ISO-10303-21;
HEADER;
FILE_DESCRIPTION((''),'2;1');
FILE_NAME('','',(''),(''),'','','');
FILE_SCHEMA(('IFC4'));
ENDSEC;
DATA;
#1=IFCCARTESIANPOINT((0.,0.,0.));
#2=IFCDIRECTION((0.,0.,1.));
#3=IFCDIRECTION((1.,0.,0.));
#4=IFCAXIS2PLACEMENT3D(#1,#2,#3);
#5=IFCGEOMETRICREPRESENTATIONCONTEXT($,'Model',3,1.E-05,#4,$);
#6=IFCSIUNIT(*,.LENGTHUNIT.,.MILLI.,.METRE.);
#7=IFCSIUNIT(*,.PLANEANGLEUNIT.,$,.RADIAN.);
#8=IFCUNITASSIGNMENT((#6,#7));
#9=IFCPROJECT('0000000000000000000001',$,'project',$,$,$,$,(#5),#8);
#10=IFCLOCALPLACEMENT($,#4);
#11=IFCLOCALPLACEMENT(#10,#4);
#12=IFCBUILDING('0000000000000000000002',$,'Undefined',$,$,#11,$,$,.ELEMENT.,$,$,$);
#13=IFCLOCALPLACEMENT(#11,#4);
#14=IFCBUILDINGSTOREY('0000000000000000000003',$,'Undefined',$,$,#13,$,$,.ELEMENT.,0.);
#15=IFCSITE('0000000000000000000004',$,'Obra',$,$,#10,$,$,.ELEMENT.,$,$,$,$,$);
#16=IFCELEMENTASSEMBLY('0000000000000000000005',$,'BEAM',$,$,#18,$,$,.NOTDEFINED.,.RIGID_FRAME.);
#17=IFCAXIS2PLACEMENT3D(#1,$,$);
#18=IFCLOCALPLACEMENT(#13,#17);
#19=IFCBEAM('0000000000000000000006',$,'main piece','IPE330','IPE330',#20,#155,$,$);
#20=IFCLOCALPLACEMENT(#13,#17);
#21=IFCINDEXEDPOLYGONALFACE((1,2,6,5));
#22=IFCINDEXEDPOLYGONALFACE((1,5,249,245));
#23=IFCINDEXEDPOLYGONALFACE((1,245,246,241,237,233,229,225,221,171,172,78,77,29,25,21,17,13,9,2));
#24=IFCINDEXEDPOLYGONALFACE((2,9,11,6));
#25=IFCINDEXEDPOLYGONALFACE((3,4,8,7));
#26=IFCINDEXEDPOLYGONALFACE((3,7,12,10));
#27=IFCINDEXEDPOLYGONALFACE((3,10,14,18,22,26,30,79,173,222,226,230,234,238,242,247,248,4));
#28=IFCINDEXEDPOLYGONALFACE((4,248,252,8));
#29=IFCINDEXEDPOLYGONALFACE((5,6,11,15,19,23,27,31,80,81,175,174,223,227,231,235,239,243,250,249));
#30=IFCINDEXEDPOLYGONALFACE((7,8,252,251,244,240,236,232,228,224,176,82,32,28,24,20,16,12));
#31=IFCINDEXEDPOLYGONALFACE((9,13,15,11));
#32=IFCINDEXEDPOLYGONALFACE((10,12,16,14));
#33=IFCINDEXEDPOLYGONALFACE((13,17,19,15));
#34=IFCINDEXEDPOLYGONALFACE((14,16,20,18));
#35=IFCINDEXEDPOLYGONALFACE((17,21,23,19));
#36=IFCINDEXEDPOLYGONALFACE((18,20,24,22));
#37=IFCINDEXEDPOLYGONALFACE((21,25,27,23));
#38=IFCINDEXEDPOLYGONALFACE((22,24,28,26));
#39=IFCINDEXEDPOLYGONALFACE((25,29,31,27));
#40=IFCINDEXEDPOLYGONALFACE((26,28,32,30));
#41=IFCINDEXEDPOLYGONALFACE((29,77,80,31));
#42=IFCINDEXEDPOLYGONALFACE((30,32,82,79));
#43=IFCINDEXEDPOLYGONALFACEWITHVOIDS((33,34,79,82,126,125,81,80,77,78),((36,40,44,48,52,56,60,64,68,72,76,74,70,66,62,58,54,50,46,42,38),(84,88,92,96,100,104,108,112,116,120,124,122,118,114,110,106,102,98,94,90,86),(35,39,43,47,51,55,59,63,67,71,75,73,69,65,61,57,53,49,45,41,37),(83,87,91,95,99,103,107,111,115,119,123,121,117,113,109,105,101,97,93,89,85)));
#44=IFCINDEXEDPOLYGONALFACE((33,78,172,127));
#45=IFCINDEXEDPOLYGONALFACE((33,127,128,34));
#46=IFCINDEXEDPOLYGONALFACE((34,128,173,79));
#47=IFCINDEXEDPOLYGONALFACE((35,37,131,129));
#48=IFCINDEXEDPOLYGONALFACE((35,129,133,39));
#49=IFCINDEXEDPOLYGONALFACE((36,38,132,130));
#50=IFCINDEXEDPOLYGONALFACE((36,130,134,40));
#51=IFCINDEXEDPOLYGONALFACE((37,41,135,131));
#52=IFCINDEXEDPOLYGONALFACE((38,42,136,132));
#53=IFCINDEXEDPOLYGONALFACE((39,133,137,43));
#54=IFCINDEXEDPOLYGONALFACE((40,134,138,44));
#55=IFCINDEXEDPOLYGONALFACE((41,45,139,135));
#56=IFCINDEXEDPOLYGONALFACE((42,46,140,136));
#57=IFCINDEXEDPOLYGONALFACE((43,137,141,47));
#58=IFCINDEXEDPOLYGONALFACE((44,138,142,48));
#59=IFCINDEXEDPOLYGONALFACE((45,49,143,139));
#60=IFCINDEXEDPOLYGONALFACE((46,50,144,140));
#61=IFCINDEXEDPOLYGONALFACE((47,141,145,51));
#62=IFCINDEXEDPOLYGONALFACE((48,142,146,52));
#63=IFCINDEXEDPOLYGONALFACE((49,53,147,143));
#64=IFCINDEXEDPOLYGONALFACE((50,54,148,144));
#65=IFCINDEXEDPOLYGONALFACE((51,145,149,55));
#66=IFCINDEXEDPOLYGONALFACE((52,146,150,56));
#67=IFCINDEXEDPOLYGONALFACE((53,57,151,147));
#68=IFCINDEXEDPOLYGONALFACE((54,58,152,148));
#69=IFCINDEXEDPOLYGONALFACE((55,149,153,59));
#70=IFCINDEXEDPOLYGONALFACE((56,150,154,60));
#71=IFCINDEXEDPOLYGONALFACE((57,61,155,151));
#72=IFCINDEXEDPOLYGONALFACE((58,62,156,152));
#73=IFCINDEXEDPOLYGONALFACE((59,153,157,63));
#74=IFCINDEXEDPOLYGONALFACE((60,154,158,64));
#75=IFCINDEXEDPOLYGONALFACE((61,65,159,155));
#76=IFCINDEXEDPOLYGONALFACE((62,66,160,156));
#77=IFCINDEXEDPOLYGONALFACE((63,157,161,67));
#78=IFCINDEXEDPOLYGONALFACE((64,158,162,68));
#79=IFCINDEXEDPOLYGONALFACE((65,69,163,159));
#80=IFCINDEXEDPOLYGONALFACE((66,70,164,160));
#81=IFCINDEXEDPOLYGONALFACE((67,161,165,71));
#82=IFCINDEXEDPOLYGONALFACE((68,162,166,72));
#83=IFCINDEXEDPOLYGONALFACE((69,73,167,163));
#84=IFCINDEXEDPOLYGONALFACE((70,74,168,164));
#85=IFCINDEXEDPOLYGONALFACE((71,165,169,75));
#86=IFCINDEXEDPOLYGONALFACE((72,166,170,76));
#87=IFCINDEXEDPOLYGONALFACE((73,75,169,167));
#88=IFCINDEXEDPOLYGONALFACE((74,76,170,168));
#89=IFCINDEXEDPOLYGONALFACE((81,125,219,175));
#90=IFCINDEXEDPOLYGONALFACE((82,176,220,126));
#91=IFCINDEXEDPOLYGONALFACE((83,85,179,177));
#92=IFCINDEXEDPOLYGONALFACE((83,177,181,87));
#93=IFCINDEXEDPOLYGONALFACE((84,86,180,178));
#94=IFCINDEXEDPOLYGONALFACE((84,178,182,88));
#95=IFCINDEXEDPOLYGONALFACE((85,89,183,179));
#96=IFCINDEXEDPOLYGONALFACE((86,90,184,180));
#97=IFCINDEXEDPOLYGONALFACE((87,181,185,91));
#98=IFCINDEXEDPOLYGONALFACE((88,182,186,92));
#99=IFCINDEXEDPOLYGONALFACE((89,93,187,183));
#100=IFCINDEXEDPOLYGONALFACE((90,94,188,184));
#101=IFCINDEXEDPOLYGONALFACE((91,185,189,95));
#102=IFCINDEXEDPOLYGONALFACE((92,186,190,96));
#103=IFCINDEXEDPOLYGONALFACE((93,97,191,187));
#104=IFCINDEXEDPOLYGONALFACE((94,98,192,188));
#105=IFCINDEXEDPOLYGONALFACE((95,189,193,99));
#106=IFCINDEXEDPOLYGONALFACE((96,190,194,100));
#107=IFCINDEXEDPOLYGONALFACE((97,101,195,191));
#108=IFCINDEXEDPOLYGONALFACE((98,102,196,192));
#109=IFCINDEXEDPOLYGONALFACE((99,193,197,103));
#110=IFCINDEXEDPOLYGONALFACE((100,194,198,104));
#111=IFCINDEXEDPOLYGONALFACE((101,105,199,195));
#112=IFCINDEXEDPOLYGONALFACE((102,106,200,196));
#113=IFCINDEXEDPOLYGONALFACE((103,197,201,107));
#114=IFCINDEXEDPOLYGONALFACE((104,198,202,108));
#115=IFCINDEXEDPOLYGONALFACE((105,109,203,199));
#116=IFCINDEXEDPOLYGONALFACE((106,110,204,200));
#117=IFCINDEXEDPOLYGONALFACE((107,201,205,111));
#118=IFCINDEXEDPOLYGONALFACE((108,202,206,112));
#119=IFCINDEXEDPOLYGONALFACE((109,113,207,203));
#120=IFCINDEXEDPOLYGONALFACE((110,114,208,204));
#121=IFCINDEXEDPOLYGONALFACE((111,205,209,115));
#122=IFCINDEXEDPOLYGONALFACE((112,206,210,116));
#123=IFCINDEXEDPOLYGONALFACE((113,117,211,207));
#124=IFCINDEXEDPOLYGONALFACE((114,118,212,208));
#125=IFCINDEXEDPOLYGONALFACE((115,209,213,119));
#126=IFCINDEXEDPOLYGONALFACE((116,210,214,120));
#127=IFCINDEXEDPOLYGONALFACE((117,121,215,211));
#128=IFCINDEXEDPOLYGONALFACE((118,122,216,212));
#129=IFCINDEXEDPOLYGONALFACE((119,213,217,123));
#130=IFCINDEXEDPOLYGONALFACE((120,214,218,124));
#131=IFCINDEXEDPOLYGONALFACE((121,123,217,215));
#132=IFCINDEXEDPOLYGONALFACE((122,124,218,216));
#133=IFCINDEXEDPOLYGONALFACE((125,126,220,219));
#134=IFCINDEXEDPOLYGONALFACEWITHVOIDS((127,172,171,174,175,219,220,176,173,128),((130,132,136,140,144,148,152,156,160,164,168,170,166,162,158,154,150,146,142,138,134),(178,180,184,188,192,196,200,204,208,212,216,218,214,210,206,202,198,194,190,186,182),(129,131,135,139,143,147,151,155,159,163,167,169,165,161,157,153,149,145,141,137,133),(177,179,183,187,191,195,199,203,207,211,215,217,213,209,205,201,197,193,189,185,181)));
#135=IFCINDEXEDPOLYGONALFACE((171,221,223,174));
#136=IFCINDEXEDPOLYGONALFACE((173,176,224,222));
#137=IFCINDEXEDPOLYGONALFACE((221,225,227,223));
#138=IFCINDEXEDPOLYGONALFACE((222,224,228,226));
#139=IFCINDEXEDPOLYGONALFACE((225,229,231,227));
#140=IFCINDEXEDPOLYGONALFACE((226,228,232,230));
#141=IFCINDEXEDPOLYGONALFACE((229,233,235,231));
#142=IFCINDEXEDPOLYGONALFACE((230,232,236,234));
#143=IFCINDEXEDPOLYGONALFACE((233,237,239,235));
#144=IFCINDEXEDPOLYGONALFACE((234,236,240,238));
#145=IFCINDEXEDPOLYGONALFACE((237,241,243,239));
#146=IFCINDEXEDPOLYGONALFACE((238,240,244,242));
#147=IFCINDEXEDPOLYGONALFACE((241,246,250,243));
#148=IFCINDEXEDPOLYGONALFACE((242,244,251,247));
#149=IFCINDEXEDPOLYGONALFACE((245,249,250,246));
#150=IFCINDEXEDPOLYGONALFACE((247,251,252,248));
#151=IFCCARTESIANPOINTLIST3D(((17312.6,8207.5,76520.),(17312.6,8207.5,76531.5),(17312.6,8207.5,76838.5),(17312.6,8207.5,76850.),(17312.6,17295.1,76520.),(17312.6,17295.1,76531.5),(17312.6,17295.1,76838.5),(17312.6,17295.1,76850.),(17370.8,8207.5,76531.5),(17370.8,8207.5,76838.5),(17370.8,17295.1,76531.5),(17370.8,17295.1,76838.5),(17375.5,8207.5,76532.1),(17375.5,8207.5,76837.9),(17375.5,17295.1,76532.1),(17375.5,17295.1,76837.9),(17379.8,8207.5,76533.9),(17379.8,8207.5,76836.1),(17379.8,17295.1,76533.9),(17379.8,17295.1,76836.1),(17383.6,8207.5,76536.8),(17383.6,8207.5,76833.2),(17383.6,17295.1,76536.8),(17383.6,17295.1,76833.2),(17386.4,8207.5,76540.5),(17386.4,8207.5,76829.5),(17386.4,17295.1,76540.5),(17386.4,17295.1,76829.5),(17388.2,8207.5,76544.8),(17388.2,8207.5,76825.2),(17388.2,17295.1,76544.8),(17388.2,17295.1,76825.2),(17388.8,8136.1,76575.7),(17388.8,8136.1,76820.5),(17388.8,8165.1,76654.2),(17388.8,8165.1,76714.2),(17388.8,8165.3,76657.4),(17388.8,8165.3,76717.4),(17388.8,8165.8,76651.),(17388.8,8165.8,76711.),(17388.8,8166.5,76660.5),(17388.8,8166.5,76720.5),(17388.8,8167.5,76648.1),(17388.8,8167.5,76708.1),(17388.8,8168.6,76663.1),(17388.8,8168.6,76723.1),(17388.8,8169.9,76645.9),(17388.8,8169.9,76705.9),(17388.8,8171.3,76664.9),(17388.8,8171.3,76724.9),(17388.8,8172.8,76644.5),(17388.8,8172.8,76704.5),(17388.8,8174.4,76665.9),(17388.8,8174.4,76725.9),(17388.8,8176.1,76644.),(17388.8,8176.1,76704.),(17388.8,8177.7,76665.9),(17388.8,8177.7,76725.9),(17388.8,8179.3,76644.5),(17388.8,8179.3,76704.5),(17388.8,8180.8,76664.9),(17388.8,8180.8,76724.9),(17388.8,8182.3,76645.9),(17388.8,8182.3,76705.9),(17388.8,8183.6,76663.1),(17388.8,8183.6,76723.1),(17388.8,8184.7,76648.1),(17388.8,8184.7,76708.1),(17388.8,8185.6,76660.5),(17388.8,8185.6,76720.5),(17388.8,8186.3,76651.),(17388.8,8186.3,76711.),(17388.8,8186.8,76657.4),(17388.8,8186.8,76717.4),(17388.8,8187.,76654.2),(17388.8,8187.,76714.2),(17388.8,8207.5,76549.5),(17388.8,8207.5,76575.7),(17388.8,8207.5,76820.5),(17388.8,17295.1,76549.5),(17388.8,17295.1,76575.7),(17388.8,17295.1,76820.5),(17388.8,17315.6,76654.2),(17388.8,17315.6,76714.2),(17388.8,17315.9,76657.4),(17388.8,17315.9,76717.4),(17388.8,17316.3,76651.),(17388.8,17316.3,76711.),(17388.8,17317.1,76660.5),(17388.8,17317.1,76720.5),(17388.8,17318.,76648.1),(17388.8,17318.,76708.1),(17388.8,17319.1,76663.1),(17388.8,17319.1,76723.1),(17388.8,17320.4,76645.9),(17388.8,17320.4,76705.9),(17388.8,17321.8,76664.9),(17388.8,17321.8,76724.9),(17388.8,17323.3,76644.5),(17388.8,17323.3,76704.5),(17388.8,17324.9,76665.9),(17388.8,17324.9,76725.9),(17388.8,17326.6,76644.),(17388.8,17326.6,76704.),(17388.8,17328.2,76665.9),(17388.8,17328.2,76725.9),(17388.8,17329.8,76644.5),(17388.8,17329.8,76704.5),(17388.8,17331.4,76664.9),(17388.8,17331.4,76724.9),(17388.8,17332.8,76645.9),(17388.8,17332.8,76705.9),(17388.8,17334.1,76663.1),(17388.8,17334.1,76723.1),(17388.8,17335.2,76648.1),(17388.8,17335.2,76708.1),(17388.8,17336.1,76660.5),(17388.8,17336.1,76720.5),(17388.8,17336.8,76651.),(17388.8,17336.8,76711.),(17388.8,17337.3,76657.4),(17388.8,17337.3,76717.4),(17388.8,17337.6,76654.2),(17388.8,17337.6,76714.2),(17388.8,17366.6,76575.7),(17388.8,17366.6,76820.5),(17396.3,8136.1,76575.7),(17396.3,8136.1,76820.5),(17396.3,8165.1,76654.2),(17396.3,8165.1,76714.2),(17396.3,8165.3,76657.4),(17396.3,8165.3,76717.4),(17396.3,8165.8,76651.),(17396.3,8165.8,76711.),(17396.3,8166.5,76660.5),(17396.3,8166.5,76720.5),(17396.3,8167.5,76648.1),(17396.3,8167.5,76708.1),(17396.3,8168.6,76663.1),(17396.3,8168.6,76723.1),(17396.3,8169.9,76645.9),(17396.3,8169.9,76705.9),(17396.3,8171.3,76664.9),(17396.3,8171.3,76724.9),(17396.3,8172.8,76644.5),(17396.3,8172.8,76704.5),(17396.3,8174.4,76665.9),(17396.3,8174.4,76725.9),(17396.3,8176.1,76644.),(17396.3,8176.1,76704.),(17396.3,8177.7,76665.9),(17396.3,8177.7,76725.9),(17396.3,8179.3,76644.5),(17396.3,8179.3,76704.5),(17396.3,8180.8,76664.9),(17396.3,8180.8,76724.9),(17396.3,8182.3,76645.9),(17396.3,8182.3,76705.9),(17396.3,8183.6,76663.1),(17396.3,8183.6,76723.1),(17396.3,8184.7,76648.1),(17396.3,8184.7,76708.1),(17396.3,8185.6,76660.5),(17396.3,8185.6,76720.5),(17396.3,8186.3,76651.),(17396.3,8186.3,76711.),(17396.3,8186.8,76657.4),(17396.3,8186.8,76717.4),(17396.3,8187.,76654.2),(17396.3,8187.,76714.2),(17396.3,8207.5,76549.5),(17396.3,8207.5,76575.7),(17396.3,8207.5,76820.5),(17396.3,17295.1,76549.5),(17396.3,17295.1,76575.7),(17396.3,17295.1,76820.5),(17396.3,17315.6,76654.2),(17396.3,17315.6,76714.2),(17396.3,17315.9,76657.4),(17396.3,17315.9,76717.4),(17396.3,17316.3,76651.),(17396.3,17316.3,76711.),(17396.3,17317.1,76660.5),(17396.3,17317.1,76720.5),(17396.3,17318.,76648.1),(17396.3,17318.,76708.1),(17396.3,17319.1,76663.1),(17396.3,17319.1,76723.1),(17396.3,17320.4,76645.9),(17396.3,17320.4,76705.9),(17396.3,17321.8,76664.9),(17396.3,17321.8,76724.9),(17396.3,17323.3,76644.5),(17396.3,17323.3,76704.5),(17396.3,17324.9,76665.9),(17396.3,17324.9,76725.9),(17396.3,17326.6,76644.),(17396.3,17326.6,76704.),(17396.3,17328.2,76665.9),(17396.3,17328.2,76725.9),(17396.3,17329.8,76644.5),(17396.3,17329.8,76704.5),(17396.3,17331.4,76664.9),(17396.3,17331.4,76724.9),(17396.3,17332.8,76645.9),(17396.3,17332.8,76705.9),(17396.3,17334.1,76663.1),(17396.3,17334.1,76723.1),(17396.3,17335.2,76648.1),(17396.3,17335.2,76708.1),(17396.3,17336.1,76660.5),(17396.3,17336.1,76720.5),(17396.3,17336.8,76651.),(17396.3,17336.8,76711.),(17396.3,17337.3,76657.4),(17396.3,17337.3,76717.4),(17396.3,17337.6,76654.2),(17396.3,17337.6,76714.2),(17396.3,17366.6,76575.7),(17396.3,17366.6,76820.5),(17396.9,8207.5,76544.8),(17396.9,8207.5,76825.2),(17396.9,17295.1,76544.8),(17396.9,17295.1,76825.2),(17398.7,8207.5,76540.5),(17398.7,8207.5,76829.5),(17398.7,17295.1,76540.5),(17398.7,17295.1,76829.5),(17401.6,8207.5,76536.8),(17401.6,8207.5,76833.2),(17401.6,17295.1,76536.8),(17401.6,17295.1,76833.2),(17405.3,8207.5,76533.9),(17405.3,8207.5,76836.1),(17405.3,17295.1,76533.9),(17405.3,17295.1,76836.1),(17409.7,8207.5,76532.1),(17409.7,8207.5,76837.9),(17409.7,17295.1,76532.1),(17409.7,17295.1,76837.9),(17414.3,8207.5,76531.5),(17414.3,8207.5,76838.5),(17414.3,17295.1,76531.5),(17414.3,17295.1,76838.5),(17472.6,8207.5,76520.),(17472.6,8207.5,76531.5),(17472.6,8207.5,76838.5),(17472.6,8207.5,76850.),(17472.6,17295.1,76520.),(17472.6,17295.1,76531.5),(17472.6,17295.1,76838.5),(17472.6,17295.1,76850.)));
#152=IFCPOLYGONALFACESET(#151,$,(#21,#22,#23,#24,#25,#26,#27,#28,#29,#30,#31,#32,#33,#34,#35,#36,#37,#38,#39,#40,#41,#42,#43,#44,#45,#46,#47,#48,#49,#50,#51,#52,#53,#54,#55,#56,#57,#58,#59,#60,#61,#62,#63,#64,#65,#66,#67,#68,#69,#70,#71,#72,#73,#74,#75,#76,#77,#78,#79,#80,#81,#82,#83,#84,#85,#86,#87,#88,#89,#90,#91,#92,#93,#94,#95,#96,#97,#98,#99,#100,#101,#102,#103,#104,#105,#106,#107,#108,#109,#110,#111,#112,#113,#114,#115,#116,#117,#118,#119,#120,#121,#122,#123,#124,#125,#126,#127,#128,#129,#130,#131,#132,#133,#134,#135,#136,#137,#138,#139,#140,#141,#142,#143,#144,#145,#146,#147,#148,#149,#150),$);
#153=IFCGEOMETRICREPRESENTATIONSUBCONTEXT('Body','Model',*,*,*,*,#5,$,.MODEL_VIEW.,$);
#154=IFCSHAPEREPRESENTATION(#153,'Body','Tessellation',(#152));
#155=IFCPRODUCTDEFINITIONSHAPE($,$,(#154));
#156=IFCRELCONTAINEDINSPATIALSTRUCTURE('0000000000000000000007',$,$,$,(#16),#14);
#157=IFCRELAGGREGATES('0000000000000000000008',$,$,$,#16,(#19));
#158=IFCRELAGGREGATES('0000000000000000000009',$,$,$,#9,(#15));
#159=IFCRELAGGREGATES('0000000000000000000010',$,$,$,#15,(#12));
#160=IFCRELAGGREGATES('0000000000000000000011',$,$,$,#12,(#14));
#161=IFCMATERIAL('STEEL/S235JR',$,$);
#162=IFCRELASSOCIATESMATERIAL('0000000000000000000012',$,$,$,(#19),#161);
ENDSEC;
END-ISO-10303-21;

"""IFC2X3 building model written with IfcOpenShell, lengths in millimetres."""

from ifc_helpers import new_model, si_unit, frame, origin_with_axes, origin_2d_with_axis, place, context, subcontext, project, spatial, rectangle, circle, i_section, extrude, clip, halfspace, source, transform, mapped, material, element, aggregate, save


model = new_model("IFC2X3")

# Units and contexts
model_context = context("Model", 3, precision=1e-05, world=origin_with_axes())
body_context = subcontext(model_context, "Body", "Model", "MODEL_VIEW")
ifc_project = project(units=[si_unit("LENGTHUNIT", "METRE", prefix="MILLI"), si_unit("PLANEANGLEUNIT", "RADIAN")], contexts=[model_context])

# Site, building, storey
site_placement = place(None, origin_with_axes())
site = spatial("IfcSite", under=ifc_project, at=site_placement, Name="Obra", CompositionType="ELEMENT")
building_placement = place(site_placement, origin_with_axes())
building = spatial("IfcBuilding", under=site, at=building_placement, Name="Undefined", CompositionType="ELEMENT")
storey_placement = place(building_placement, origin_with_axes())
storey = spatial("IfcBuildingStorey", under=building, at=storey_placement, Name="Undefined", CompositionType="ELEMENT", Elevation=0.0)

# Shared definitions
ifc_material = material(Name="STEEL/S235JR")

# Element assembly, beam, openings
shared_shape_1 = source(origin_with_axes(), body_context, "Body", "SweptSolid", [
    extrude(circle(Radius=11.0, at=origin_2d_with_axis()), frame((0.0, -3.9, 0.0), z_axis=(0.0, 1.0, 0.0), x_axis=(1.0, 0.0, 0.0)), (0.0, 0.0, 1.0), 7.7),
])
assembly_1_placement = place(storey_placement, origin_with_axes())
assembly_1 = element("IfcElementAssembly", 1, at=assembly_1_placement, inside=storey, Name="BEAM", AssemblyPlace="NOTDEFINED", PredefinedType="RIGID_FRAME")
beam_1_placement = place(assembly_1_placement, frame((17392.6, 8217.5, 76685.0), z_axis=(0.0, 0.0, 1.0), x_axis=(0.0, 1.0, 0.0)))
beam_1 = element("IfcBeam", 2, at=beam_1_placement, material=ifc_material, Name="main piece", Description="IPE330", ObjectType="IPE330", context=body_context, shape_type="Clipping", body=[
    clip(clip(extrude(i_section(OverallWidth=160.0, OverallDepth=330.0, WebThickness=7.5, FlangeThickness=11.5, FilletRadius=18.0, at=origin_2d_with_axis()), frame((9149.1, 0.0, 0.0), z_axis=(-1.0, 0.0, 0.0), x_axis=(0.0, -1.0, 0.0)), (0.0, 0.0, 1.0), 9230.5), halfspace(frame((9149.1, 0.0, -265.0), z_axis=(-1.0, 0.0, 0.0), x_axis=(0.0, 1.0, 0.0)), True)), halfspace(frame((-81.4, 0.0, -265.0), z_axis=(1.0, 0.0, 0.0), x_axis=(0.0, -1.0, 0.0)), True)),
])
opening_1_placement = place(assembly_1_placement, frame((17392.6, 8217.5, 76685.0), z_axis=(0.0, 0.0, 1.0), x_axis=(0.0, 1.0, 0.0)))
element("IfcOpeningElement", 3, at=opening_1_placement, cuts=beam_1, ObjectType="Recess", context=body_context, shape_type="SweptSolid", body=[
    extrude(rectangle(XDim=56.7, YDim=83.5, at=origin_2d_with_axis()), frame((9119.3, 81.0, -137.7), z_axis=(0.0, -1.0, 0.0), x_axis=(0.0, 0.0, -1.0)), (0.0, 0.0, 1.0), 162.0),
])
opening_2_placement = place(assembly_1_placement, frame((17392.6, 8217.5, 76685.0), z_axis=(0.0, 0.0, 1.0), x_axis=(0.0, 1.0, 0.0)))
element("IfcOpeningElement", 4, at=opening_2_placement, cuts=beam_1, ObjectType="Recess", context=body_context, shape_type="SweptSolid", body=[
    extrude(rectangle(XDim=30.5, YDim=83.5, at=origin_2d_with_axis()), frame((9119.3, 81.0, 150.8), z_axis=(0.0, -1.0, 0.0), x_axis=(0.0, 0.0, -1.0)), (0.0, 0.0, 1.0), 162.0),
])
opening_3_placement = place(assembly_1_placement, frame((17392.6, 8217.5, 76685.0), z_axis=(0.0, 0.0, 1.0), x_axis=(0.0, 1.0, 0.0)))
element("IfcOpeningElement", 5, at=opening_3_placement, cuts=beam_1, ObjectType="Recess", context=body_context, shape_type="SweptSolid", body=[
    extrude(rectangle(XDim=56.7, YDim=83.5, at=origin_2d_with_axis()), frame((-51.7, -81.0, -137.7), z_axis=(0.0, 1.0, 0.0), x_axis=(0.0, 0.0, -1.0)), (0.0, 0.0, 1.0), 162.0),
])
opening_4_placement = place(assembly_1_placement, frame((17392.6, 8217.5, 76685.0), z_axis=(0.0, 0.0, 1.0), x_axis=(0.0, 1.0, 0.0)))
element("IfcOpeningElement", 6, at=opening_4_placement, cuts=beam_1, ObjectType="Recess", context=body_context, shape_type="SweptSolid", body=[
    extrude(rectangle(XDim=30.5, YDim=83.5, at=origin_2d_with_axis()), frame((-51.7, -81.0, 150.8), z_axis=(0.0, 1.0, 0.0), x_axis=(0.0, 0.0, -1.0)), (0.0, 0.0, 1.0), 162.0),
])
opening_5_placement = place(assembly_1_placement, frame((17392.6, 17366.6, 76850.0), z_axis=(0.0, -1.0, 0.0), x_axis=(0.0, 0.0, -1.0)))
element("IfcOpeningElement", 7, at=opening_5_placement, cuts=beam_1, ObjectType="Opening", context=body_context, shape_type="MappedRepresentation", body=[
    mapped(shared_shape_1, transform((135.0, 0.0, 40.0))),
    mapped(shared_shape_1, transform((195.0, 0.0, 40.0))),
])
opening_6_placement = place(assembly_1_placement, frame((17392.6, 8136.1, 76850.0), z_axis=(0.0, 1.0, 0.0), x_axis=(0.0, 0.0, -1.0)))
element("IfcOpeningElement", 8, at=opening_6_placement, cuts=beam_1, ObjectType="Opening", context=body_context, shape_type="MappedRepresentation", body=[
    mapped(shared_shape_1, transform((135.0, 0.0, 40.0))),
    mapped(shared_shape_1, transform((195.0, 0.0, 40.0))),
])
aggregate(assembly_1, [beam_1])

save(model, "model.ifc")
